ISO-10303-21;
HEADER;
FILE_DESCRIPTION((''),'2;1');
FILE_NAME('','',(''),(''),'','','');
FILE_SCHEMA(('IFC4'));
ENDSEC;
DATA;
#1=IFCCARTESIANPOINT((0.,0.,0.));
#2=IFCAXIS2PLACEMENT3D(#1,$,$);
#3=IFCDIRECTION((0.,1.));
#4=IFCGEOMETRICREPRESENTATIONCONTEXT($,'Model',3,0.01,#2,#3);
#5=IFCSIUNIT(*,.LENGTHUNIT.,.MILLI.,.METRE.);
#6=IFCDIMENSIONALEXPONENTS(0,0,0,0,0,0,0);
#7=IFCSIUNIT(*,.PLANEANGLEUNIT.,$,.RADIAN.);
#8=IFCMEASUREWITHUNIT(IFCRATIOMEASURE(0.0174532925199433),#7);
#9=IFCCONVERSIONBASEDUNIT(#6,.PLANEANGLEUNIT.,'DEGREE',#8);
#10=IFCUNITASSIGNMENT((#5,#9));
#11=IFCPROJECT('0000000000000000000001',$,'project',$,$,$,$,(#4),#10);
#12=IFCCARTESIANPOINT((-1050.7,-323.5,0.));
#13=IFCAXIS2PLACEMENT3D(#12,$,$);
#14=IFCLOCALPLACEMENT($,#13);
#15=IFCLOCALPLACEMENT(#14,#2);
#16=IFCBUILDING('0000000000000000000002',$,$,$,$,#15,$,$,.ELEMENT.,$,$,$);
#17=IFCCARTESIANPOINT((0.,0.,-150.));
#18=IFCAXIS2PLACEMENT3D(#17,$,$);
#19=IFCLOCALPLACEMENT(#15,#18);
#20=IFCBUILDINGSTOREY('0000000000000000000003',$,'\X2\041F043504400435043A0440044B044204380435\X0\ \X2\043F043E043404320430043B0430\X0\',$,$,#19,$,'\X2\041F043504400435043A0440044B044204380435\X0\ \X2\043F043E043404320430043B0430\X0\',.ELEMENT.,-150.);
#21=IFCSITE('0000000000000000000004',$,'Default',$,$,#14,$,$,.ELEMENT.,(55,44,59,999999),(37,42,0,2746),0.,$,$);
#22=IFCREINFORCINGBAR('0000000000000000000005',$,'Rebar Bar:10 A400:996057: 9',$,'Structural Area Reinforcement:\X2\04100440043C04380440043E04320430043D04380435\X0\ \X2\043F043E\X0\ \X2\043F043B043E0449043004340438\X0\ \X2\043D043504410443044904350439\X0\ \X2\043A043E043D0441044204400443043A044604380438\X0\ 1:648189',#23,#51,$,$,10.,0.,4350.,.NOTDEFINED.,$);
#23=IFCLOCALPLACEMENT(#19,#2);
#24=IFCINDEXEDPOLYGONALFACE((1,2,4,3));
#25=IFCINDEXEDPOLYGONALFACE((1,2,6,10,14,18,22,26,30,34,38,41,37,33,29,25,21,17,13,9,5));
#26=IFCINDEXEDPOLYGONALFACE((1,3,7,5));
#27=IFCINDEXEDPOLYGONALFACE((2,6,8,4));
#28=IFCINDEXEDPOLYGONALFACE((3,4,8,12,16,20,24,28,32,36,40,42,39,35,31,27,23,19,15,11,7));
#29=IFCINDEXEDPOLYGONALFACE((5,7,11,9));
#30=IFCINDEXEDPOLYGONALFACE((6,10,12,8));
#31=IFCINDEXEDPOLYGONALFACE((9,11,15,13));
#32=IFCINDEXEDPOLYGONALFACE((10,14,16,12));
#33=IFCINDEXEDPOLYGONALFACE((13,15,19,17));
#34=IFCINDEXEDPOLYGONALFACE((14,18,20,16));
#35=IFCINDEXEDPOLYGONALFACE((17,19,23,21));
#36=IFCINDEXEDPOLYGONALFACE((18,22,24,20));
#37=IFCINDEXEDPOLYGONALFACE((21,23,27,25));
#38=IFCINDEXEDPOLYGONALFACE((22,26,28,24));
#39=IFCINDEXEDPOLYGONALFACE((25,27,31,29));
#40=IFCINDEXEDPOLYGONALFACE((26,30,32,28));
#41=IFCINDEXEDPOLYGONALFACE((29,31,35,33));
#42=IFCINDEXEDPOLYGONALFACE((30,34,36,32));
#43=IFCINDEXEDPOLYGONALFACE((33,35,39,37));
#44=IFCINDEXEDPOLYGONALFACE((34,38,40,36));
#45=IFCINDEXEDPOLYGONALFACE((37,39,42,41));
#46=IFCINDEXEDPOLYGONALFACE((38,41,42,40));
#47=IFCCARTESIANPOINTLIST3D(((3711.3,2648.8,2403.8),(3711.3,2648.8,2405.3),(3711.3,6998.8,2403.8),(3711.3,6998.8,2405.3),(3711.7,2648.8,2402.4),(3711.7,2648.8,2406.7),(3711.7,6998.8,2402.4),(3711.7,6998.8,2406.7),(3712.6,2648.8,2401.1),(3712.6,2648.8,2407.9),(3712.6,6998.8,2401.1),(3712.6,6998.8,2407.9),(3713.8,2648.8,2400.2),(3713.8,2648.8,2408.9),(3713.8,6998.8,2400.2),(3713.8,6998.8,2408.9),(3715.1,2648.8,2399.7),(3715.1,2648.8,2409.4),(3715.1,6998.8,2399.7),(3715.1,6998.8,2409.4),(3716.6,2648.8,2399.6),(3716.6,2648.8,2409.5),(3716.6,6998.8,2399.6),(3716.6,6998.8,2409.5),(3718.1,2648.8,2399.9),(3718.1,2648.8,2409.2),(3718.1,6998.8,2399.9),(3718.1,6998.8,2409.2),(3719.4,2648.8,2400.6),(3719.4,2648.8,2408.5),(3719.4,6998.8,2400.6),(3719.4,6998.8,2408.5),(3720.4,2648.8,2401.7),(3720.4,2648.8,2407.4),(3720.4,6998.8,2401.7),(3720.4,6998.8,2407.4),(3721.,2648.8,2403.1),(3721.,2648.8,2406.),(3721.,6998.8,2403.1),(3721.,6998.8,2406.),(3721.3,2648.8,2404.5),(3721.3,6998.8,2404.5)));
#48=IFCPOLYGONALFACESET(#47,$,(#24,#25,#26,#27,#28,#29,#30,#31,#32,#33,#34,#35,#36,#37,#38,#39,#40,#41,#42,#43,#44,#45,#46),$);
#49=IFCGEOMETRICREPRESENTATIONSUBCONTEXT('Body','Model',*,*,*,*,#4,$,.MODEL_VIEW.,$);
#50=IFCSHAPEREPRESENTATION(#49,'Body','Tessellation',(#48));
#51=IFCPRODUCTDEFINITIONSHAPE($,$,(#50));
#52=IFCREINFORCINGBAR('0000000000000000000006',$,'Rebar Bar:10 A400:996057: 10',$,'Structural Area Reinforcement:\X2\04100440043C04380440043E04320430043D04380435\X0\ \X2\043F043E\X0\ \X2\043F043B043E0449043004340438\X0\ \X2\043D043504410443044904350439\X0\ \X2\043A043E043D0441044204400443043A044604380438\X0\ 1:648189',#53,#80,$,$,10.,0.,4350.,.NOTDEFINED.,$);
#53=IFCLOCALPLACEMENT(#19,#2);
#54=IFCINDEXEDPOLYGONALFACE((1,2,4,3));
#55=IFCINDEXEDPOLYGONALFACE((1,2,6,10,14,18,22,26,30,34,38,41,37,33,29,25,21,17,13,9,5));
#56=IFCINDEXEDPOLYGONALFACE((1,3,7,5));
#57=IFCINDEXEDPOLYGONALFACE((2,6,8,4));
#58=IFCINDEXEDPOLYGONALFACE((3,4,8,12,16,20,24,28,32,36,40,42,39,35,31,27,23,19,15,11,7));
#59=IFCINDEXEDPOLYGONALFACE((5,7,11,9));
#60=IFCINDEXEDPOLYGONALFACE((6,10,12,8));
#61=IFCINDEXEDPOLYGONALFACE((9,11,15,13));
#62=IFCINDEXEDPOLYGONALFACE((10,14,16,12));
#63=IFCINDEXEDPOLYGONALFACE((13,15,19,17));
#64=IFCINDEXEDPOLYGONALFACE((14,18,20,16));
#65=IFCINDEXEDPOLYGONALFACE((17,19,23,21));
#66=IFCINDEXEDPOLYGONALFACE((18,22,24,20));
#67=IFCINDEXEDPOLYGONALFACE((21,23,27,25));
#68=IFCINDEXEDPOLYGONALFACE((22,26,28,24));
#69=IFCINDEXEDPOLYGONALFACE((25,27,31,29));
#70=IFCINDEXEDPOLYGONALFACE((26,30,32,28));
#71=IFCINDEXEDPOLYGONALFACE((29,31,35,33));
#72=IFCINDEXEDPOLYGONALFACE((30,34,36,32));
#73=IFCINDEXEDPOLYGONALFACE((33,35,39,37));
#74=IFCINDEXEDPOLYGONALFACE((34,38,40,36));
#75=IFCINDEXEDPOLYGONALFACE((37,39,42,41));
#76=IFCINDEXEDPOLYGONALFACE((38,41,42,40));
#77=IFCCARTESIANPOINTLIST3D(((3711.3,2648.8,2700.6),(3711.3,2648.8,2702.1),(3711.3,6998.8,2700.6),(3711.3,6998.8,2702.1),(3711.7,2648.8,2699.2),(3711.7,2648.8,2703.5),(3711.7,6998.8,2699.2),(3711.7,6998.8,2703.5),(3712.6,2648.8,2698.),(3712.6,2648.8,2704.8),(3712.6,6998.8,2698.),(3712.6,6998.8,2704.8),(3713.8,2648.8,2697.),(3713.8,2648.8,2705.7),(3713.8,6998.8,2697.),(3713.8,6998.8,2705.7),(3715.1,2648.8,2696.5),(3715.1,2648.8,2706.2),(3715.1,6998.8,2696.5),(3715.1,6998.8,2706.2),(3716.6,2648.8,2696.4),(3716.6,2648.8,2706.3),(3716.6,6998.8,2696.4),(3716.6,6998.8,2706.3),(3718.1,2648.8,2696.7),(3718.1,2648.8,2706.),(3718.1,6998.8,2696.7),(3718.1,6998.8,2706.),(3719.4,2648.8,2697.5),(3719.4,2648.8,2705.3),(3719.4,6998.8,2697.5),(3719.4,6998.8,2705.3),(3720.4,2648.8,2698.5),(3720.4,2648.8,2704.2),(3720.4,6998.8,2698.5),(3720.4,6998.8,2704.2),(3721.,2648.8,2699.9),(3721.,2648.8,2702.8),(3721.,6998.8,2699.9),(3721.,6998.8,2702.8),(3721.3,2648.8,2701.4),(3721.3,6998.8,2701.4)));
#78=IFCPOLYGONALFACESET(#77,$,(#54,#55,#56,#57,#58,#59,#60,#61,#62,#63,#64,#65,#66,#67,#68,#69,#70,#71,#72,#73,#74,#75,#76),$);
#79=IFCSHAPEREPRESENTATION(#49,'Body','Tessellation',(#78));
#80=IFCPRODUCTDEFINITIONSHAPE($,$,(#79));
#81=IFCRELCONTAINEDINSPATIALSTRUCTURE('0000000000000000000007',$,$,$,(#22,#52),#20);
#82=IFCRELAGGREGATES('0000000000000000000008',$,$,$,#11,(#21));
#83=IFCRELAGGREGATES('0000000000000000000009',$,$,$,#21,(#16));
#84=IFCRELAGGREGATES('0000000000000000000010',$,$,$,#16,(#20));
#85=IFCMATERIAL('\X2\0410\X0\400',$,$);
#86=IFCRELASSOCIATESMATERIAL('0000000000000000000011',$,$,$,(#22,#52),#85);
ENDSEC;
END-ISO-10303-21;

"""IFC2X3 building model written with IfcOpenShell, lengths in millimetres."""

from ifc_helpers import new_model, entity, si_unit, converted_unit, direction, frame, origin, place, context, subcontext, project, spatial, material, element, save


model = new_model("IFC2X3")

# Units and contexts
model_context = context("Model", 3, precision=0.01, world=origin(), true_north=direction((0.0, 1.0)))
body_context = subcontext(model_context, "Body", "Model", "MODEL_VIEW")
ifc_project = project(units=[si_unit("LENGTHUNIT", "METRE", prefix="MILLI"), converted_unit("PLANEANGLEUNIT", "DEGREE", entity("IfcRatioMeasure", 0.0174532925199433), si_unit("PLANEANGLEUNIT", "RADIAN"), dimensions=[0, 0, 0, 0, 0, 0, 0])], contexts=[model_context])

# Site, building, storey
site_placement = place(None, frame((-1050.7, -323.5, 0.0)))
site = spatial("IfcSite", under=ifc_project, at=site_placement, Name="Default", CompositionType="ELEMENT", RefLatitude=(55, 44, 59, 999999), RefLongitude=(37, 42, 0, 2746), RefElevation=0.0)
building_placement = place(site_placement, origin())
building = spatial("IfcBuilding", under=site, at=building_placement, CompositionType="ELEMENT")
storey_placement = place(building_placement, frame((0.0, 0.0, -150.0)))
storey = spatial("IfcBuildingStorey", under=building, at=storey_placement, Name="Перекрытие подвала", LongName="Перекрытие подвала", CompositionType="ELEMENT", Elevation=-150.0)

# Reinforcing bars
ifc_material = material(Name="А400")
reinforcing_bar_1_placement = place(storey_placement, origin())
element("IfcReinforcingBar", 1, at=reinforcing_bar_1_placement, inside=storey, material=ifc_material, Name="Rebar Bar:10 A400:996057: 9", ObjectType="Structural Area Reinforcement:Армирование по площади несущей конструкции 1:648189", BarLength=4350.0, BarRole="NOTDEFINED", CrossSectionArea=0.0, NominalDiameter=10.0, context=body_context, shape_type="AdvancedSweptSolid", body=[
    entity("IfcSweptDiskSolid", entity("IfcCompositeCurve", [entity("IfcCompositeCurveSegment", "CONTINUOUS", True, entity("IfcPolyline", [entity("IfcCartesianPoint", [3716.3, 2648.8, 2404.5]), entity("IfcCartesianPoint", [3716.3, 6998.8, 2404.5])]))], False), 5.0, None, 0.0, 1.0),
])
reinforcing_bar_2_placement = place(storey_placement, origin())
element("IfcReinforcingBar", 2, at=reinforcing_bar_2_placement, inside=storey, material=ifc_material, Name="Rebar Bar:10 A400:996057: 10", ObjectType="Structural Area Reinforcement:Армирование по площади несущей конструкции 1:648189", BarLength=4350.0, BarRole="NOTDEFINED", CrossSectionArea=0.0, NominalDiameter=10.0, context=body_context, shape_type="AdvancedSweptSolid", body=[
    entity("IfcSweptDiskSolid", entity("IfcCompositeCurve", [entity("IfcCompositeCurveSegment", "CONTINUOUS", True, entity("IfcPolyline", [entity("IfcCartesianPoint", [3716.3, 2648.8, 2701.4]), entity("IfcCartesianPoint", [3716.3, 6998.8, 2701.4])]))], False), 5.0, None, 0.0, 1.0),
])

save(model, "model.ifc")
